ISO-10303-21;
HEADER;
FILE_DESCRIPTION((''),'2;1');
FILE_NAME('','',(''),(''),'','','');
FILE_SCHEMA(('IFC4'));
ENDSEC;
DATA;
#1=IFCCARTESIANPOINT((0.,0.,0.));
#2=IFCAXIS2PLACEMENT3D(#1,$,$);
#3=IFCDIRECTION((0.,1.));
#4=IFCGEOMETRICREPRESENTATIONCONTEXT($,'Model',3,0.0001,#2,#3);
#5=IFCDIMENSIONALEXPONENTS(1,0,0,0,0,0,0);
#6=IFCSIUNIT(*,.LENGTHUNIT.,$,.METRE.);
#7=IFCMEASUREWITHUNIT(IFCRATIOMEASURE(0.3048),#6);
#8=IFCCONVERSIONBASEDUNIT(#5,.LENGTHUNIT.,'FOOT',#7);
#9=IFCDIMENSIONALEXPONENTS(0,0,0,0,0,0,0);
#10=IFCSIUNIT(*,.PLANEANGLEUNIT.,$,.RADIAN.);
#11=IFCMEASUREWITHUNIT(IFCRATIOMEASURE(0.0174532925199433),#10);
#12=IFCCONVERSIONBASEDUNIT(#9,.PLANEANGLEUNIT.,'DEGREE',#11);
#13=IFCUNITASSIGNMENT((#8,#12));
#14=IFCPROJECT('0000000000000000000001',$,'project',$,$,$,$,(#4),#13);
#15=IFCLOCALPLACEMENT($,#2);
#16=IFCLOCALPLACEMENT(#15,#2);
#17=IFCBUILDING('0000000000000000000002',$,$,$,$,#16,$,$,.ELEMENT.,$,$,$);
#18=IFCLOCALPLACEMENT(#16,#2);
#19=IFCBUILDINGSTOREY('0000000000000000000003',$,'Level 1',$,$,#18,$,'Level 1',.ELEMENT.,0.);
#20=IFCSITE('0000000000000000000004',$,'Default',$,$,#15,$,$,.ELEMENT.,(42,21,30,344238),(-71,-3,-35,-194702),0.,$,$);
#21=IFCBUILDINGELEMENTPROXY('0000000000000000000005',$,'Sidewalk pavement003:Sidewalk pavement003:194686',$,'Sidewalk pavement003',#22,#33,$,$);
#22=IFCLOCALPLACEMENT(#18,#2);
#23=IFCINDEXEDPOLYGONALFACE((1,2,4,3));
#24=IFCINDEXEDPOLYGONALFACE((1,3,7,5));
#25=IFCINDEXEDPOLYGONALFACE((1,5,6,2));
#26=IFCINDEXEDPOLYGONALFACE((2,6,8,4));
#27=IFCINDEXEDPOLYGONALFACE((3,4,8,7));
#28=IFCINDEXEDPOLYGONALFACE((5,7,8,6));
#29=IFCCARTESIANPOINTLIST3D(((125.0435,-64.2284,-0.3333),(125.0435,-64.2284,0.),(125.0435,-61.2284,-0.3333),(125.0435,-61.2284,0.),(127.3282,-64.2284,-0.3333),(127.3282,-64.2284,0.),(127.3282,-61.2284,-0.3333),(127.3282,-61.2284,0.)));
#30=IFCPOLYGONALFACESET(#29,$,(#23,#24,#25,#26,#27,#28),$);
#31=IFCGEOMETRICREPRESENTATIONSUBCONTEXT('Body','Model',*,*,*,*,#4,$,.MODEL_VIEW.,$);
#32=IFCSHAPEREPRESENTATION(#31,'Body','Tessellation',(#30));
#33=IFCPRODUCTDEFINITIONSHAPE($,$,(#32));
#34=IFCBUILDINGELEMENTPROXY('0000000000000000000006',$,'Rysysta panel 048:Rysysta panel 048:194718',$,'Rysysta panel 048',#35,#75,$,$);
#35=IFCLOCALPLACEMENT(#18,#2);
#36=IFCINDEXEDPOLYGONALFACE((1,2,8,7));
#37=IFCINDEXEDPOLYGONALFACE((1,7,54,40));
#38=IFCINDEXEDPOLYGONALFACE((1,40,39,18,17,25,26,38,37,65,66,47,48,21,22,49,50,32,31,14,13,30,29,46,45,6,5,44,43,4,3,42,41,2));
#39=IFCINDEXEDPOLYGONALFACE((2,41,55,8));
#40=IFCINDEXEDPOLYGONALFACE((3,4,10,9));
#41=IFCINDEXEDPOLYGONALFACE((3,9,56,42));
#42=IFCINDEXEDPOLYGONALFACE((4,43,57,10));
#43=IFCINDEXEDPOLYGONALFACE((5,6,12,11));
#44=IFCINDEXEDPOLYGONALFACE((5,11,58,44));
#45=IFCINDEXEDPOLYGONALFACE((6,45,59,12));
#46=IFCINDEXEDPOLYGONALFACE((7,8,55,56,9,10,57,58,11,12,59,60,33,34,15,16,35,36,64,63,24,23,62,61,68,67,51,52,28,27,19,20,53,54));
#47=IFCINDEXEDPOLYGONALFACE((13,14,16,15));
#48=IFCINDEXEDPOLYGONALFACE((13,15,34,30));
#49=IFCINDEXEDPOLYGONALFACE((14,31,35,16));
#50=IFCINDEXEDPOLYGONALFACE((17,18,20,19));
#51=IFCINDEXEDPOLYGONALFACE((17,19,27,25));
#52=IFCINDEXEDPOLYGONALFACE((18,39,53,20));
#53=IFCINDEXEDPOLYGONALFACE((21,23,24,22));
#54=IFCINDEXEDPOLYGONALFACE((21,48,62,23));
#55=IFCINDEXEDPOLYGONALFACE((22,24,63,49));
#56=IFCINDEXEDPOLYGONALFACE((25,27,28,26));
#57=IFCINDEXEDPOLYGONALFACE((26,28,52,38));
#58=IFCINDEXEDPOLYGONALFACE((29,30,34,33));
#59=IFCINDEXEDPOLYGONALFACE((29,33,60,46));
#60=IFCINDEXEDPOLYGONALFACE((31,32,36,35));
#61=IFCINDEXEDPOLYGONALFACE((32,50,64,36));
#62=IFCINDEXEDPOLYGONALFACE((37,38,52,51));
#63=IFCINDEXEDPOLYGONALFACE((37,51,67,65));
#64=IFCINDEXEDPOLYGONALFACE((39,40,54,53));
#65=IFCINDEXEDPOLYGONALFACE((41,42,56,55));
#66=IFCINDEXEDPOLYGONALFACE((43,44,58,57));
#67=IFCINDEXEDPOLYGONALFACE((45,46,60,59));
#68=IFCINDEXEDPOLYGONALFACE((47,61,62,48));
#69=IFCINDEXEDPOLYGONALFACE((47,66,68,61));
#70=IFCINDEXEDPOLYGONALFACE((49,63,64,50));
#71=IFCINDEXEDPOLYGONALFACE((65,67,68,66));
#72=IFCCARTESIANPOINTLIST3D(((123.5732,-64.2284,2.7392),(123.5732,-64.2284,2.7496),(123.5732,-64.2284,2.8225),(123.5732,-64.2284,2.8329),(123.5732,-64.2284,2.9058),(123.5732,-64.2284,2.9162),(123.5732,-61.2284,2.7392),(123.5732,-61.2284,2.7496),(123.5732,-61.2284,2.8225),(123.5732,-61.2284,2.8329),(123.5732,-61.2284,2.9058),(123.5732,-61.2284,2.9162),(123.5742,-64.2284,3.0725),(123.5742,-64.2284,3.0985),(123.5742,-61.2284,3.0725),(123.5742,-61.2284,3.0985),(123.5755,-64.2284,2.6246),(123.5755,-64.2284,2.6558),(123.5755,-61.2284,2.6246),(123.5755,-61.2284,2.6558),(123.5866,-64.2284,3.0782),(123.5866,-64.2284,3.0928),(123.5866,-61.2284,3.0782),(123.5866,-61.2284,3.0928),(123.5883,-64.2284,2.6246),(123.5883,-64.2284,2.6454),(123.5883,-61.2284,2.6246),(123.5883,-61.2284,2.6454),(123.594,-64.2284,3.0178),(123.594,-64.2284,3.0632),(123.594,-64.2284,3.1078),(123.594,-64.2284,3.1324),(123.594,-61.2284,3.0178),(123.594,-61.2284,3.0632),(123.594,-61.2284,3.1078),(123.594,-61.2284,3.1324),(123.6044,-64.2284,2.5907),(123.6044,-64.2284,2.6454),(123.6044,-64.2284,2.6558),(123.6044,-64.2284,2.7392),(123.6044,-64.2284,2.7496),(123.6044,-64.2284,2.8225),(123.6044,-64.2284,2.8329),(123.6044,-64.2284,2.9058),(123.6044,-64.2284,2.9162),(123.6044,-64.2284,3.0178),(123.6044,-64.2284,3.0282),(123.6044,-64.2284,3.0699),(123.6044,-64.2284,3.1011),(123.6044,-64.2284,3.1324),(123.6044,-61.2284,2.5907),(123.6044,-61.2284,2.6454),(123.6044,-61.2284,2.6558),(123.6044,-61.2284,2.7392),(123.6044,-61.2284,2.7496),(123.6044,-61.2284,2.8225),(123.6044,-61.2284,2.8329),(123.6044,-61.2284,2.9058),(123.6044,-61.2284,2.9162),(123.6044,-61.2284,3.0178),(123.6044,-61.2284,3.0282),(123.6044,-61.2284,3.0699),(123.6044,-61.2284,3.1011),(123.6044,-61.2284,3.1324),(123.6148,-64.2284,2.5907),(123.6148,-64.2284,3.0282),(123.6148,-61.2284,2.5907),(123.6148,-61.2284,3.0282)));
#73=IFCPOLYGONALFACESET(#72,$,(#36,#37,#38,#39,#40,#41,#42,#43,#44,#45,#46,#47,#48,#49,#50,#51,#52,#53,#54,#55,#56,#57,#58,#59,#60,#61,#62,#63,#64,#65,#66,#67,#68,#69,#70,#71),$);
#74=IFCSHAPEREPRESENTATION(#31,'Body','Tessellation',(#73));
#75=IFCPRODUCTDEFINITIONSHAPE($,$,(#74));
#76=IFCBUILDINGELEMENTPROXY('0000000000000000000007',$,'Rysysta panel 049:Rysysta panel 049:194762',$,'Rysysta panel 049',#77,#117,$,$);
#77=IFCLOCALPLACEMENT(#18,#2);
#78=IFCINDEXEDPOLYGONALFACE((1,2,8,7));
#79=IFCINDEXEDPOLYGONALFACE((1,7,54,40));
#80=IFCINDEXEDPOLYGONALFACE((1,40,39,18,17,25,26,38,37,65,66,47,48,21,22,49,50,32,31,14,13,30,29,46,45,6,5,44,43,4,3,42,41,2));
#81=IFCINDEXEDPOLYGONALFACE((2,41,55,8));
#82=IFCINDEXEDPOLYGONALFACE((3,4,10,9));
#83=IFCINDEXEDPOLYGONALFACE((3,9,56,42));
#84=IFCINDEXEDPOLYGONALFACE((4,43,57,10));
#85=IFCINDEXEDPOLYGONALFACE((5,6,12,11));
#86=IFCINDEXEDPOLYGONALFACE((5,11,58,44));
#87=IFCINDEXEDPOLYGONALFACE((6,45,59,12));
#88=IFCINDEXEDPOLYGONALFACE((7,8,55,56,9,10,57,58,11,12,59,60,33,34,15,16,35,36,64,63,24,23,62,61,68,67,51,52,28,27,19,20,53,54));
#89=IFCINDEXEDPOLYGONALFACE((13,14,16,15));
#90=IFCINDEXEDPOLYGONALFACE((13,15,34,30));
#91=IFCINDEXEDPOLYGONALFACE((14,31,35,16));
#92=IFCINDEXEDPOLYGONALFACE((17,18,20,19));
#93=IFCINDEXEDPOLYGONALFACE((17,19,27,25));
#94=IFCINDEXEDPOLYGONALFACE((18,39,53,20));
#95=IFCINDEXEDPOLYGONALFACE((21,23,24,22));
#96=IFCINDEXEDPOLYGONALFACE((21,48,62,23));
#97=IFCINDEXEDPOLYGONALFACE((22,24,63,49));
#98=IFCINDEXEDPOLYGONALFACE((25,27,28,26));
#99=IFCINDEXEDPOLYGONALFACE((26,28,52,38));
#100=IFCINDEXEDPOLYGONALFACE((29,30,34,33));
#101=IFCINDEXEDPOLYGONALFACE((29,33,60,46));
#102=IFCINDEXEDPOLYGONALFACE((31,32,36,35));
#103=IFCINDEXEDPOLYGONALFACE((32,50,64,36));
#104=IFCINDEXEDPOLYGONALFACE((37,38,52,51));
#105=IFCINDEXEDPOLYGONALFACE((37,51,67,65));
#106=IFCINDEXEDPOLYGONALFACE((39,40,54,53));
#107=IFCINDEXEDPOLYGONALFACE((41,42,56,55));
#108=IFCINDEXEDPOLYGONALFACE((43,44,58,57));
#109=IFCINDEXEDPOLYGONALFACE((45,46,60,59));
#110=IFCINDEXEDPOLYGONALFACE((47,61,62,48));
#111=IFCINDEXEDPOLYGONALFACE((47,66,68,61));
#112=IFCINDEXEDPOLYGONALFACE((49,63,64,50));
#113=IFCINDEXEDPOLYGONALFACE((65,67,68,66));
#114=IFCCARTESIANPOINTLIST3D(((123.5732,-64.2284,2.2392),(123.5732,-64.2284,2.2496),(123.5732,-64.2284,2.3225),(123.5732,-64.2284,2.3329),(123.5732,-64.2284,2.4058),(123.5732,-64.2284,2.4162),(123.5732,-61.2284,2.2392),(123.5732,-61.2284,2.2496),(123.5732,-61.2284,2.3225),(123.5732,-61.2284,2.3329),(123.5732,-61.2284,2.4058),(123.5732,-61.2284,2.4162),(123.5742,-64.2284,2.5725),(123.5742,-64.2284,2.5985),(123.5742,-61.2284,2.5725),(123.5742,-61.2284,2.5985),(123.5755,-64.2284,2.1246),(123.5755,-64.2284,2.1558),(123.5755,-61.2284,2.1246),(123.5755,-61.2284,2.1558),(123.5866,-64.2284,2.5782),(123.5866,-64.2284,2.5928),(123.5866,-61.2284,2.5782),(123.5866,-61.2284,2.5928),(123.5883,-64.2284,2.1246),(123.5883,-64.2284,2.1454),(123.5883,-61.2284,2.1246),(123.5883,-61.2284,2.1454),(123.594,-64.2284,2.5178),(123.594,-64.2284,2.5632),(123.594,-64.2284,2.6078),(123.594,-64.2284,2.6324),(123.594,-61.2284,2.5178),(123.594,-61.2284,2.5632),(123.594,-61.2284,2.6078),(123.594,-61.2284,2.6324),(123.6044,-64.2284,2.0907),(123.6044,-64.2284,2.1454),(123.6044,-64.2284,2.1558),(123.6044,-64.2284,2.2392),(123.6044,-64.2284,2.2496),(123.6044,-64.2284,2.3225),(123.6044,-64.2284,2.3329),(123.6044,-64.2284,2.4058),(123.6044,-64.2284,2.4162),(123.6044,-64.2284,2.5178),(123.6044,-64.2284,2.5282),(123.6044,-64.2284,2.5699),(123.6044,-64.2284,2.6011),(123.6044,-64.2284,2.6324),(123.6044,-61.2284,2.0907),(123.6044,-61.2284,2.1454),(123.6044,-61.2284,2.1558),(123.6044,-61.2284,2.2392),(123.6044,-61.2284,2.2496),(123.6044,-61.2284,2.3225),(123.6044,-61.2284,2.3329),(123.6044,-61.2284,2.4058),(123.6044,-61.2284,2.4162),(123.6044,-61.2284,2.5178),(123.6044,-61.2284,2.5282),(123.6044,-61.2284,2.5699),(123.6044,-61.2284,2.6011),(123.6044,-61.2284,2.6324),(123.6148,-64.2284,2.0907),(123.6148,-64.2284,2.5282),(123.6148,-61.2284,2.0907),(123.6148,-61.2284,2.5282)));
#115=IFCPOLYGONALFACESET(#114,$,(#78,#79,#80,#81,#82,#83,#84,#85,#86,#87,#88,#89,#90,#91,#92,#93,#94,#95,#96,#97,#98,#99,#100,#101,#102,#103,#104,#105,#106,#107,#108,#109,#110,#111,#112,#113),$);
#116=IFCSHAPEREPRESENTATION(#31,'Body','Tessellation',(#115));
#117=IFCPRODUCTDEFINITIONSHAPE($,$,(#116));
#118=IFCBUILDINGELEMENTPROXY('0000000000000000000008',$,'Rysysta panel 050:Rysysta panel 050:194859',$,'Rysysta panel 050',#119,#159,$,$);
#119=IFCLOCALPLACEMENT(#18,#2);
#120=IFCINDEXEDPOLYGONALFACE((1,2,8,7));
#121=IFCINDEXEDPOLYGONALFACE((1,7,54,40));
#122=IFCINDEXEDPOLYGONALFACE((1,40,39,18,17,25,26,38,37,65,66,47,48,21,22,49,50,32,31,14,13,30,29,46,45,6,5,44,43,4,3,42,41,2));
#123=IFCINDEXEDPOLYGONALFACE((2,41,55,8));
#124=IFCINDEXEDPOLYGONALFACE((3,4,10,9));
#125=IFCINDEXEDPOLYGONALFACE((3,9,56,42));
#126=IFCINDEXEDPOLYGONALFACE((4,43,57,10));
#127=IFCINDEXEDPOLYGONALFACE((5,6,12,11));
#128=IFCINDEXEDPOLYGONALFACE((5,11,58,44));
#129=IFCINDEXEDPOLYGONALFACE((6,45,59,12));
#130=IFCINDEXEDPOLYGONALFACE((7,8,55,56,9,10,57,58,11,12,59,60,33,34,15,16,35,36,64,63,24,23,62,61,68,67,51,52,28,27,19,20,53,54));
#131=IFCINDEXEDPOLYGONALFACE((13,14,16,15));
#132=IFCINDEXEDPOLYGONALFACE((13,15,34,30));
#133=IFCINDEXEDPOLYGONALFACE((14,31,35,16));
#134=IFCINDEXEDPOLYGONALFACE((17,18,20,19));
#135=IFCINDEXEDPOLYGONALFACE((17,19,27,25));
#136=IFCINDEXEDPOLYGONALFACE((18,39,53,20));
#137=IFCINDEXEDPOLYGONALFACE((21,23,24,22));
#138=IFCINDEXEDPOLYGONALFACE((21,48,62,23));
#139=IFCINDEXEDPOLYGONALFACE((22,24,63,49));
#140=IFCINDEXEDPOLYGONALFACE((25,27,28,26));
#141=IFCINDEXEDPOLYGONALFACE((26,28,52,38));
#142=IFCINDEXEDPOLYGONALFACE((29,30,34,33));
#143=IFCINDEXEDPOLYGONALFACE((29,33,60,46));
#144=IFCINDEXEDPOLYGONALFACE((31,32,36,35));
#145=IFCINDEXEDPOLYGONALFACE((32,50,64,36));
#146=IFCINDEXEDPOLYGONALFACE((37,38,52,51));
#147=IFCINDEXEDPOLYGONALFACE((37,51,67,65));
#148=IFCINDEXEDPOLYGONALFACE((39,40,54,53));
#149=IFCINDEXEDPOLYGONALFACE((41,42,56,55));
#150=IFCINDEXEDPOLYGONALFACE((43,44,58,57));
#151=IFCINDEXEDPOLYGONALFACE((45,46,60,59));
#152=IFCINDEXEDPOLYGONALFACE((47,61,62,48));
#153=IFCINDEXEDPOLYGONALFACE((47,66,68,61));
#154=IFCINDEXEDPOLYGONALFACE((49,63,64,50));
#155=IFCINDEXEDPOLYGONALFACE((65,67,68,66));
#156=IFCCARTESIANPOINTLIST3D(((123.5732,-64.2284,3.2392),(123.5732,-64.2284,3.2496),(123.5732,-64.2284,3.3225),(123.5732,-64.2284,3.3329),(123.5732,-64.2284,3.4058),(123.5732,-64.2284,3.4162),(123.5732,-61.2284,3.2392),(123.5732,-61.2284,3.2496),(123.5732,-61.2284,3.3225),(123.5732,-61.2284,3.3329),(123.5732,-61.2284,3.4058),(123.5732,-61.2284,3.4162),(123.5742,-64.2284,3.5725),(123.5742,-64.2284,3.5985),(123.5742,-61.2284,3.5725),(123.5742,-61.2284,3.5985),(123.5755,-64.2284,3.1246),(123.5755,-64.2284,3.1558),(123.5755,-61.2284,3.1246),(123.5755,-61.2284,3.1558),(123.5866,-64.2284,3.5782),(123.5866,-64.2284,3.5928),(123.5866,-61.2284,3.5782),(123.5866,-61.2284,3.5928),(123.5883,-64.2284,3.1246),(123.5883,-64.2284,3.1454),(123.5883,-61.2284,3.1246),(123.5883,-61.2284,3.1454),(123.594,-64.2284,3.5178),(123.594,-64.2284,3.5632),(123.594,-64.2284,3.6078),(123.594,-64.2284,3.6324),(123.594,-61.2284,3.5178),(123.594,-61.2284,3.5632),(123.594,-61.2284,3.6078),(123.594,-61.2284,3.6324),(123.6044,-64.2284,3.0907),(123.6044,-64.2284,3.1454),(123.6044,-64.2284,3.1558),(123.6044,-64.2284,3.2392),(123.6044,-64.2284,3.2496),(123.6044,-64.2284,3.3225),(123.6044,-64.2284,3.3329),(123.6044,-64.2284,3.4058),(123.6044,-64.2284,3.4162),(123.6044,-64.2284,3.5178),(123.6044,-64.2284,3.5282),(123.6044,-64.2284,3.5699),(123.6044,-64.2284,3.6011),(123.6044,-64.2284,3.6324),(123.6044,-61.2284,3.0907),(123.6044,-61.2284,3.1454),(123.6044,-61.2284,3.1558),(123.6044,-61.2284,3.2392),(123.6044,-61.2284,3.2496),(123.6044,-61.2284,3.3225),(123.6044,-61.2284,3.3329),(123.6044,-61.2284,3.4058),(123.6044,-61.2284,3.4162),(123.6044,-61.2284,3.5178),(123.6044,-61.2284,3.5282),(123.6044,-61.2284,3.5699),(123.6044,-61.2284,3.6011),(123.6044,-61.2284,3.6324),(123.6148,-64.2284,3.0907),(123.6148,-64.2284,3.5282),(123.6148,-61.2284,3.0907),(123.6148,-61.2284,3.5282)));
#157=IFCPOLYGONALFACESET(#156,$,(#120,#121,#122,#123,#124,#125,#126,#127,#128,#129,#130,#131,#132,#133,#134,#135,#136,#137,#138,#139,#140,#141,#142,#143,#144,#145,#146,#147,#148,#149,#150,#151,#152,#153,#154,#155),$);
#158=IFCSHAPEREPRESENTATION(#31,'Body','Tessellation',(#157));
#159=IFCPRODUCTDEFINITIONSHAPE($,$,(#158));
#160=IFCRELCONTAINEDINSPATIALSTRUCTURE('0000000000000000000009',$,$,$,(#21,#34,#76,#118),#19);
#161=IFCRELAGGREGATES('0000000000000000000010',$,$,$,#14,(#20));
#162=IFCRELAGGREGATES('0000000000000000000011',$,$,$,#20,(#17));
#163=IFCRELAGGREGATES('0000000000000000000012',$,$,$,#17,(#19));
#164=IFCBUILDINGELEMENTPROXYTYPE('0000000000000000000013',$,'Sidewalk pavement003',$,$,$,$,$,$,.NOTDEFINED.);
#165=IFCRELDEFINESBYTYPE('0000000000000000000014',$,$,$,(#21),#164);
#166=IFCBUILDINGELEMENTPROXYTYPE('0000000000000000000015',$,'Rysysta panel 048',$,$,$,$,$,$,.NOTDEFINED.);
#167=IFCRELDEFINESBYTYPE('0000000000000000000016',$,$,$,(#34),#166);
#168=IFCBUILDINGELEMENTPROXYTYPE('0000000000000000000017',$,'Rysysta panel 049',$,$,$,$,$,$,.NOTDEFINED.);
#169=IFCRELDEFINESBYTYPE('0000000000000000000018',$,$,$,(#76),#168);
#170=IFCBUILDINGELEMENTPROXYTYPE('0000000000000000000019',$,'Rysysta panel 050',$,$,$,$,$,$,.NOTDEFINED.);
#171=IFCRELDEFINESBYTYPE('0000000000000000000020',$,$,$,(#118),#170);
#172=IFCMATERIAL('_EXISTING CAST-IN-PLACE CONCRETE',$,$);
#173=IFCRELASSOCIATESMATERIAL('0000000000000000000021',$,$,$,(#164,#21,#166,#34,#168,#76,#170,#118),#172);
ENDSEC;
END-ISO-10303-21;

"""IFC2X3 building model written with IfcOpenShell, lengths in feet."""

from ifc_helpers import new_model, entity, si_unit, converted_unit, direction, frame, origin, origin_2d_with_axis, place, context, subcontext, project, spatial, polyline, rectangle, outline, extrude, source, transform, mapped, material, type_object, type_shapes, element, save


model = new_model("IFC2X3")

# Units and contexts
model_context = context("Model", 3, precision=0.0001, world=origin(), true_north=direction((0.0, 1.0)))
body_context = subcontext(model_context, "Body", "Model", "MODEL_VIEW")
ifc_project = project(units=[converted_unit("LENGTHUNIT", "FOOT", entity("IfcRatioMeasure", 0.3048), si_unit("LENGTHUNIT", "METRE"), dimensions=[1, 0, 0, 0, 0, 0, 0]), converted_unit("PLANEANGLEUNIT", "DEGREE", entity("IfcRatioMeasure", 0.0174532925199433), si_unit("PLANEANGLEUNIT", "RADIAN"), dimensions=[0, 0, 0, 0, 0, 0, 0])], contexts=[model_context])

# Site, building, storey
site_placement = place(None, origin())
site = spatial("IfcSite", under=ifc_project, at=site_placement, Name="Default", CompositionType="ELEMENT", RefLatitude=(42, 21, 30, 344238), RefLongitude=(-71, -3, -35, -194702), RefElevation=0.0)
building_placement = place(site_placement, origin())
building = spatial("IfcBuilding", under=site, at=building_placement, CompositionType="ELEMENT")
storey_placement = place(building_placement, origin())
storey = spatial("IfcBuildingStorey", under=building, at=storey_placement, Name="Level 1", LongName="Level 1", CompositionType="ELEMENT", Elevation=0.0)

# Building element proxies
ifc_material_1 = material(Name="_EXISTING CAST-IN-PLACE CONCRETE")
building_element_proxy_type_1 = type_object("IfcBuildingElementProxyType", Name="Sidewalk pavement003", PredefinedType="NOTDEFINED", material=ifc_material_1)
shared_shape_1 = source(origin(), body_context, "Body", "SweptSolid", [
    extrude(rectangle(XDim=3.0, YDim=2.2847, at=origin_2d_with_axis()), frame((126.1859, -62.7284, -0.3333), z_axis=(0.0, 0.0, 1.0), x_axis=(0.0, 1.0, 0.0)), (0.0, 0.0, 1.0), 0.3333),
])
type_shapes(building_element_proxy_type_1, [shared_shape_1])
proxy_1_placement = place(storey_placement, origin())
element("IfcBuildingElementProxy", 1, at=proxy_1_placement, inside=storey, type_object=building_element_proxy_type_1, material=ifc_material_1, Name="Sidewalk pavement003:Sidewalk pavement003:194686", ObjectType="Sidewalk pavement003", context=body_context, shape_type="MappedRepresentation", body=[
    mapped(shared_shape_1, transform((0.0, 0.0, 0.0), scale=1.0)),
])
building_element_proxy_type_2 = type_object("IfcBuildingElementProxyType", Name="Rysysta panel 048", PredefinedType="NOTDEFINED", material=ifc_material_1)
shared_shape_2 = source(origin(), body_context, "Body", "SweptSolid", [
    extrude(outline(polyline([(-0.1457, -0.022), (0.2918, -0.022), (0.2918, -0.0116), (0.2371, -0.0116), (0.2371, 0.0045), (0.258, 0.0045), (0.258, 0.0173), (0.2267, 0.0173), (0.2267, -0.0116), (0.1434, -0.0116), (0.1434, 0.0196), (0.133, 0.0196), (0.133, -0.0116), (0.06, -0.0116), (0.06, 0.0196), (0.0496, 0.0196), (0.0496, -0.0116), (-0.0233, -0.0116), (-0.0233, 0.0196), (-0.0337, 0.0196), (-0.0337, -0.0116), (-0.1353, -0.0116), (-0.1353, -0.0012), (-0.1807, -0.0012), (-0.1899, 0.0186), (-0.216, 0.0186), (-0.2252, -0.0012), (-0.2498, -0.0012), (-0.2498, -0.0116), (-0.2186, -0.0116), (-0.2103, 0.0062), (-0.1956, 0.0062), (-0.1873, -0.0116), (-0.1457, -0.0116), (-0.1457, -0.022)])), frame((123.5928, -64.2284, 2.8825), z_axis=(0.0, 1.0, 0.0), x_axis=(0.0, 0.0, -1.0)), (0.0, 0.0, 1.0), 3.0),
])
type_shapes(building_element_proxy_type_2, [shared_shape_2])
proxy_2_placement = place(storey_placement, origin())
element("IfcBuildingElementProxy", 2, at=proxy_2_placement, inside=storey, type_object=building_element_proxy_type_2, material=ifc_material_1, Name="Rysysta panel 048:Rysysta panel 048:194718", ObjectType="Rysysta panel 048", context=body_context, shape_type="MappedRepresentation", body=[
    mapped(shared_shape_2, transform((0.0, 0.0, 0.0), scale=1.0)),
])
building_element_proxy_type_3 = type_object("IfcBuildingElementProxyType", Name="Rysysta panel 049", PredefinedType="NOTDEFINED", material=ifc_material_1)
shared_shape_3 = source(origin(), body_context, "Body", "SweptSolid", [
    extrude(outline(polyline([(-0.1457, -0.022), (0.2918, -0.022), (0.2918, -0.0116), (0.2371, -0.0116), (0.2371, 0.0045), (0.258, 0.0045), (0.258, 0.0173), (0.2267, 0.0173), (0.2267, -0.0116), (0.1434, -0.0116), (0.1434, 0.0196), (0.133, 0.0196), (0.133, -0.0116), (0.06, -0.0116), (0.06, 0.0196), (0.0496, 0.0196), (0.0496, -0.0116), (-0.0233, -0.0116), (-0.0233, 0.0196), (-0.0337, 0.0196), (-0.0337, -0.0116), (-0.1353, -0.0116), (-0.1353, -0.0012), (-0.1807, -0.0012), (-0.1899, 0.0186), (-0.216, 0.0186), (-0.2252, -0.0012), (-0.2498, -0.0012), (-0.2498, -0.0116), (-0.2186, -0.0116), (-0.2103, 0.0062), (-0.1956, 0.0062), (-0.1873, -0.0116), (-0.1457, -0.0116), (-0.1457, -0.022)])), frame((123.5928, -64.2284, 2.3825), z_axis=(0.0, 1.0, 0.0), x_axis=(0.0, 0.0, -1.0)), (0.0, 0.0, 1.0), 3.0),
])
type_shapes(building_element_proxy_type_3, [shared_shape_3])
proxy_3_placement = place(storey_placement, origin())
element("IfcBuildingElementProxy", 3, at=proxy_3_placement, inside=storey, type_object=building_element_proxy_type_3, material=ifc_material_1, Name="Rysysta panel 049:Rysysta panel 049:194762", ObjectType="Rysysta panel 049", context=body_context, shape_type="MappedRepresentation", body=[
    mapped(shared_shape_3, transform((0.0, 0.0, 0.0), scale=1.0)),
])
building_element_proxy_type_4 = type_object("IfcBuildingElementProxyType", Name="Rysysta panel 050", PredefinedType="NOTDEFINED", material=ifc_material_1)
shared_shape_4 = source(origin(), body_context, "Body", "SweptSolid", [
    extrude(outline(polyline([(-0.1457, -0.022), (0.2918, -0.022), (0.2918, -0.0116), (0.2371, -0.0116), (0.2371, 0.0045), (0.258, 0.0045), (0.258, 0.0173), (0.2267, 0.0173), (0.2267, -0.0116), (0.1434, -0.0116), (0.1434, 0.0196), (0.133, 0.0196), (0.133, -0.0116), (0.06, -0.0116), (0.06, 0.0196), (0.0496, 0.0196), (0.0496, -0.0116), (-0.0233, -0.0116), (-0.0233, 0.0196), (-0.0337, 0.0196), (-0.0337, -0.0116), (-0.1353, -0.0116), (-0.1353, -0.0012), (-0.1807, -0.0012), (-0.1899, 0.0186), (-0.216, 0.0186), (-0.2252, -0.0012), (-0.2498, -0.0012), (-0.2498, -0.0116), (-0.2186, -0.0116), (-0.2103, 0.0062), (-0.1956, 0.0062), (-0.1873, -0.0116), (-0.1457, -0.0116), (-0.1457, -0.022)])), frame((123.5928, -64.2284, 3.3825), z_axis=(0.0, 1.0, 0.0), x_axis=(0.0, 0.0, -1.0)), (0.0, 0.0, 1.0), 3.0),
])
type_shapes(building_element_proxy_type_4, [shared_shape_4])
proxy_4_placement = place(storey_placement, origin())
element("IfcBuildingElementProxy", 4, at=proxy_4_placement, inside=storey, type_object=building_element_proxy_type_4, material=ifc_material_1, Name="Rysysta panel 050:Rysysta panel 050:194859", ObjectType="Rysysta panel 050", context=body_context, shape_type="MappedRepresentation", body=[
    mapped(shared_shape_4, transform((0.0, 0.0, 0.0), scale=1.0)),
])

save(model, "model.ifc")
